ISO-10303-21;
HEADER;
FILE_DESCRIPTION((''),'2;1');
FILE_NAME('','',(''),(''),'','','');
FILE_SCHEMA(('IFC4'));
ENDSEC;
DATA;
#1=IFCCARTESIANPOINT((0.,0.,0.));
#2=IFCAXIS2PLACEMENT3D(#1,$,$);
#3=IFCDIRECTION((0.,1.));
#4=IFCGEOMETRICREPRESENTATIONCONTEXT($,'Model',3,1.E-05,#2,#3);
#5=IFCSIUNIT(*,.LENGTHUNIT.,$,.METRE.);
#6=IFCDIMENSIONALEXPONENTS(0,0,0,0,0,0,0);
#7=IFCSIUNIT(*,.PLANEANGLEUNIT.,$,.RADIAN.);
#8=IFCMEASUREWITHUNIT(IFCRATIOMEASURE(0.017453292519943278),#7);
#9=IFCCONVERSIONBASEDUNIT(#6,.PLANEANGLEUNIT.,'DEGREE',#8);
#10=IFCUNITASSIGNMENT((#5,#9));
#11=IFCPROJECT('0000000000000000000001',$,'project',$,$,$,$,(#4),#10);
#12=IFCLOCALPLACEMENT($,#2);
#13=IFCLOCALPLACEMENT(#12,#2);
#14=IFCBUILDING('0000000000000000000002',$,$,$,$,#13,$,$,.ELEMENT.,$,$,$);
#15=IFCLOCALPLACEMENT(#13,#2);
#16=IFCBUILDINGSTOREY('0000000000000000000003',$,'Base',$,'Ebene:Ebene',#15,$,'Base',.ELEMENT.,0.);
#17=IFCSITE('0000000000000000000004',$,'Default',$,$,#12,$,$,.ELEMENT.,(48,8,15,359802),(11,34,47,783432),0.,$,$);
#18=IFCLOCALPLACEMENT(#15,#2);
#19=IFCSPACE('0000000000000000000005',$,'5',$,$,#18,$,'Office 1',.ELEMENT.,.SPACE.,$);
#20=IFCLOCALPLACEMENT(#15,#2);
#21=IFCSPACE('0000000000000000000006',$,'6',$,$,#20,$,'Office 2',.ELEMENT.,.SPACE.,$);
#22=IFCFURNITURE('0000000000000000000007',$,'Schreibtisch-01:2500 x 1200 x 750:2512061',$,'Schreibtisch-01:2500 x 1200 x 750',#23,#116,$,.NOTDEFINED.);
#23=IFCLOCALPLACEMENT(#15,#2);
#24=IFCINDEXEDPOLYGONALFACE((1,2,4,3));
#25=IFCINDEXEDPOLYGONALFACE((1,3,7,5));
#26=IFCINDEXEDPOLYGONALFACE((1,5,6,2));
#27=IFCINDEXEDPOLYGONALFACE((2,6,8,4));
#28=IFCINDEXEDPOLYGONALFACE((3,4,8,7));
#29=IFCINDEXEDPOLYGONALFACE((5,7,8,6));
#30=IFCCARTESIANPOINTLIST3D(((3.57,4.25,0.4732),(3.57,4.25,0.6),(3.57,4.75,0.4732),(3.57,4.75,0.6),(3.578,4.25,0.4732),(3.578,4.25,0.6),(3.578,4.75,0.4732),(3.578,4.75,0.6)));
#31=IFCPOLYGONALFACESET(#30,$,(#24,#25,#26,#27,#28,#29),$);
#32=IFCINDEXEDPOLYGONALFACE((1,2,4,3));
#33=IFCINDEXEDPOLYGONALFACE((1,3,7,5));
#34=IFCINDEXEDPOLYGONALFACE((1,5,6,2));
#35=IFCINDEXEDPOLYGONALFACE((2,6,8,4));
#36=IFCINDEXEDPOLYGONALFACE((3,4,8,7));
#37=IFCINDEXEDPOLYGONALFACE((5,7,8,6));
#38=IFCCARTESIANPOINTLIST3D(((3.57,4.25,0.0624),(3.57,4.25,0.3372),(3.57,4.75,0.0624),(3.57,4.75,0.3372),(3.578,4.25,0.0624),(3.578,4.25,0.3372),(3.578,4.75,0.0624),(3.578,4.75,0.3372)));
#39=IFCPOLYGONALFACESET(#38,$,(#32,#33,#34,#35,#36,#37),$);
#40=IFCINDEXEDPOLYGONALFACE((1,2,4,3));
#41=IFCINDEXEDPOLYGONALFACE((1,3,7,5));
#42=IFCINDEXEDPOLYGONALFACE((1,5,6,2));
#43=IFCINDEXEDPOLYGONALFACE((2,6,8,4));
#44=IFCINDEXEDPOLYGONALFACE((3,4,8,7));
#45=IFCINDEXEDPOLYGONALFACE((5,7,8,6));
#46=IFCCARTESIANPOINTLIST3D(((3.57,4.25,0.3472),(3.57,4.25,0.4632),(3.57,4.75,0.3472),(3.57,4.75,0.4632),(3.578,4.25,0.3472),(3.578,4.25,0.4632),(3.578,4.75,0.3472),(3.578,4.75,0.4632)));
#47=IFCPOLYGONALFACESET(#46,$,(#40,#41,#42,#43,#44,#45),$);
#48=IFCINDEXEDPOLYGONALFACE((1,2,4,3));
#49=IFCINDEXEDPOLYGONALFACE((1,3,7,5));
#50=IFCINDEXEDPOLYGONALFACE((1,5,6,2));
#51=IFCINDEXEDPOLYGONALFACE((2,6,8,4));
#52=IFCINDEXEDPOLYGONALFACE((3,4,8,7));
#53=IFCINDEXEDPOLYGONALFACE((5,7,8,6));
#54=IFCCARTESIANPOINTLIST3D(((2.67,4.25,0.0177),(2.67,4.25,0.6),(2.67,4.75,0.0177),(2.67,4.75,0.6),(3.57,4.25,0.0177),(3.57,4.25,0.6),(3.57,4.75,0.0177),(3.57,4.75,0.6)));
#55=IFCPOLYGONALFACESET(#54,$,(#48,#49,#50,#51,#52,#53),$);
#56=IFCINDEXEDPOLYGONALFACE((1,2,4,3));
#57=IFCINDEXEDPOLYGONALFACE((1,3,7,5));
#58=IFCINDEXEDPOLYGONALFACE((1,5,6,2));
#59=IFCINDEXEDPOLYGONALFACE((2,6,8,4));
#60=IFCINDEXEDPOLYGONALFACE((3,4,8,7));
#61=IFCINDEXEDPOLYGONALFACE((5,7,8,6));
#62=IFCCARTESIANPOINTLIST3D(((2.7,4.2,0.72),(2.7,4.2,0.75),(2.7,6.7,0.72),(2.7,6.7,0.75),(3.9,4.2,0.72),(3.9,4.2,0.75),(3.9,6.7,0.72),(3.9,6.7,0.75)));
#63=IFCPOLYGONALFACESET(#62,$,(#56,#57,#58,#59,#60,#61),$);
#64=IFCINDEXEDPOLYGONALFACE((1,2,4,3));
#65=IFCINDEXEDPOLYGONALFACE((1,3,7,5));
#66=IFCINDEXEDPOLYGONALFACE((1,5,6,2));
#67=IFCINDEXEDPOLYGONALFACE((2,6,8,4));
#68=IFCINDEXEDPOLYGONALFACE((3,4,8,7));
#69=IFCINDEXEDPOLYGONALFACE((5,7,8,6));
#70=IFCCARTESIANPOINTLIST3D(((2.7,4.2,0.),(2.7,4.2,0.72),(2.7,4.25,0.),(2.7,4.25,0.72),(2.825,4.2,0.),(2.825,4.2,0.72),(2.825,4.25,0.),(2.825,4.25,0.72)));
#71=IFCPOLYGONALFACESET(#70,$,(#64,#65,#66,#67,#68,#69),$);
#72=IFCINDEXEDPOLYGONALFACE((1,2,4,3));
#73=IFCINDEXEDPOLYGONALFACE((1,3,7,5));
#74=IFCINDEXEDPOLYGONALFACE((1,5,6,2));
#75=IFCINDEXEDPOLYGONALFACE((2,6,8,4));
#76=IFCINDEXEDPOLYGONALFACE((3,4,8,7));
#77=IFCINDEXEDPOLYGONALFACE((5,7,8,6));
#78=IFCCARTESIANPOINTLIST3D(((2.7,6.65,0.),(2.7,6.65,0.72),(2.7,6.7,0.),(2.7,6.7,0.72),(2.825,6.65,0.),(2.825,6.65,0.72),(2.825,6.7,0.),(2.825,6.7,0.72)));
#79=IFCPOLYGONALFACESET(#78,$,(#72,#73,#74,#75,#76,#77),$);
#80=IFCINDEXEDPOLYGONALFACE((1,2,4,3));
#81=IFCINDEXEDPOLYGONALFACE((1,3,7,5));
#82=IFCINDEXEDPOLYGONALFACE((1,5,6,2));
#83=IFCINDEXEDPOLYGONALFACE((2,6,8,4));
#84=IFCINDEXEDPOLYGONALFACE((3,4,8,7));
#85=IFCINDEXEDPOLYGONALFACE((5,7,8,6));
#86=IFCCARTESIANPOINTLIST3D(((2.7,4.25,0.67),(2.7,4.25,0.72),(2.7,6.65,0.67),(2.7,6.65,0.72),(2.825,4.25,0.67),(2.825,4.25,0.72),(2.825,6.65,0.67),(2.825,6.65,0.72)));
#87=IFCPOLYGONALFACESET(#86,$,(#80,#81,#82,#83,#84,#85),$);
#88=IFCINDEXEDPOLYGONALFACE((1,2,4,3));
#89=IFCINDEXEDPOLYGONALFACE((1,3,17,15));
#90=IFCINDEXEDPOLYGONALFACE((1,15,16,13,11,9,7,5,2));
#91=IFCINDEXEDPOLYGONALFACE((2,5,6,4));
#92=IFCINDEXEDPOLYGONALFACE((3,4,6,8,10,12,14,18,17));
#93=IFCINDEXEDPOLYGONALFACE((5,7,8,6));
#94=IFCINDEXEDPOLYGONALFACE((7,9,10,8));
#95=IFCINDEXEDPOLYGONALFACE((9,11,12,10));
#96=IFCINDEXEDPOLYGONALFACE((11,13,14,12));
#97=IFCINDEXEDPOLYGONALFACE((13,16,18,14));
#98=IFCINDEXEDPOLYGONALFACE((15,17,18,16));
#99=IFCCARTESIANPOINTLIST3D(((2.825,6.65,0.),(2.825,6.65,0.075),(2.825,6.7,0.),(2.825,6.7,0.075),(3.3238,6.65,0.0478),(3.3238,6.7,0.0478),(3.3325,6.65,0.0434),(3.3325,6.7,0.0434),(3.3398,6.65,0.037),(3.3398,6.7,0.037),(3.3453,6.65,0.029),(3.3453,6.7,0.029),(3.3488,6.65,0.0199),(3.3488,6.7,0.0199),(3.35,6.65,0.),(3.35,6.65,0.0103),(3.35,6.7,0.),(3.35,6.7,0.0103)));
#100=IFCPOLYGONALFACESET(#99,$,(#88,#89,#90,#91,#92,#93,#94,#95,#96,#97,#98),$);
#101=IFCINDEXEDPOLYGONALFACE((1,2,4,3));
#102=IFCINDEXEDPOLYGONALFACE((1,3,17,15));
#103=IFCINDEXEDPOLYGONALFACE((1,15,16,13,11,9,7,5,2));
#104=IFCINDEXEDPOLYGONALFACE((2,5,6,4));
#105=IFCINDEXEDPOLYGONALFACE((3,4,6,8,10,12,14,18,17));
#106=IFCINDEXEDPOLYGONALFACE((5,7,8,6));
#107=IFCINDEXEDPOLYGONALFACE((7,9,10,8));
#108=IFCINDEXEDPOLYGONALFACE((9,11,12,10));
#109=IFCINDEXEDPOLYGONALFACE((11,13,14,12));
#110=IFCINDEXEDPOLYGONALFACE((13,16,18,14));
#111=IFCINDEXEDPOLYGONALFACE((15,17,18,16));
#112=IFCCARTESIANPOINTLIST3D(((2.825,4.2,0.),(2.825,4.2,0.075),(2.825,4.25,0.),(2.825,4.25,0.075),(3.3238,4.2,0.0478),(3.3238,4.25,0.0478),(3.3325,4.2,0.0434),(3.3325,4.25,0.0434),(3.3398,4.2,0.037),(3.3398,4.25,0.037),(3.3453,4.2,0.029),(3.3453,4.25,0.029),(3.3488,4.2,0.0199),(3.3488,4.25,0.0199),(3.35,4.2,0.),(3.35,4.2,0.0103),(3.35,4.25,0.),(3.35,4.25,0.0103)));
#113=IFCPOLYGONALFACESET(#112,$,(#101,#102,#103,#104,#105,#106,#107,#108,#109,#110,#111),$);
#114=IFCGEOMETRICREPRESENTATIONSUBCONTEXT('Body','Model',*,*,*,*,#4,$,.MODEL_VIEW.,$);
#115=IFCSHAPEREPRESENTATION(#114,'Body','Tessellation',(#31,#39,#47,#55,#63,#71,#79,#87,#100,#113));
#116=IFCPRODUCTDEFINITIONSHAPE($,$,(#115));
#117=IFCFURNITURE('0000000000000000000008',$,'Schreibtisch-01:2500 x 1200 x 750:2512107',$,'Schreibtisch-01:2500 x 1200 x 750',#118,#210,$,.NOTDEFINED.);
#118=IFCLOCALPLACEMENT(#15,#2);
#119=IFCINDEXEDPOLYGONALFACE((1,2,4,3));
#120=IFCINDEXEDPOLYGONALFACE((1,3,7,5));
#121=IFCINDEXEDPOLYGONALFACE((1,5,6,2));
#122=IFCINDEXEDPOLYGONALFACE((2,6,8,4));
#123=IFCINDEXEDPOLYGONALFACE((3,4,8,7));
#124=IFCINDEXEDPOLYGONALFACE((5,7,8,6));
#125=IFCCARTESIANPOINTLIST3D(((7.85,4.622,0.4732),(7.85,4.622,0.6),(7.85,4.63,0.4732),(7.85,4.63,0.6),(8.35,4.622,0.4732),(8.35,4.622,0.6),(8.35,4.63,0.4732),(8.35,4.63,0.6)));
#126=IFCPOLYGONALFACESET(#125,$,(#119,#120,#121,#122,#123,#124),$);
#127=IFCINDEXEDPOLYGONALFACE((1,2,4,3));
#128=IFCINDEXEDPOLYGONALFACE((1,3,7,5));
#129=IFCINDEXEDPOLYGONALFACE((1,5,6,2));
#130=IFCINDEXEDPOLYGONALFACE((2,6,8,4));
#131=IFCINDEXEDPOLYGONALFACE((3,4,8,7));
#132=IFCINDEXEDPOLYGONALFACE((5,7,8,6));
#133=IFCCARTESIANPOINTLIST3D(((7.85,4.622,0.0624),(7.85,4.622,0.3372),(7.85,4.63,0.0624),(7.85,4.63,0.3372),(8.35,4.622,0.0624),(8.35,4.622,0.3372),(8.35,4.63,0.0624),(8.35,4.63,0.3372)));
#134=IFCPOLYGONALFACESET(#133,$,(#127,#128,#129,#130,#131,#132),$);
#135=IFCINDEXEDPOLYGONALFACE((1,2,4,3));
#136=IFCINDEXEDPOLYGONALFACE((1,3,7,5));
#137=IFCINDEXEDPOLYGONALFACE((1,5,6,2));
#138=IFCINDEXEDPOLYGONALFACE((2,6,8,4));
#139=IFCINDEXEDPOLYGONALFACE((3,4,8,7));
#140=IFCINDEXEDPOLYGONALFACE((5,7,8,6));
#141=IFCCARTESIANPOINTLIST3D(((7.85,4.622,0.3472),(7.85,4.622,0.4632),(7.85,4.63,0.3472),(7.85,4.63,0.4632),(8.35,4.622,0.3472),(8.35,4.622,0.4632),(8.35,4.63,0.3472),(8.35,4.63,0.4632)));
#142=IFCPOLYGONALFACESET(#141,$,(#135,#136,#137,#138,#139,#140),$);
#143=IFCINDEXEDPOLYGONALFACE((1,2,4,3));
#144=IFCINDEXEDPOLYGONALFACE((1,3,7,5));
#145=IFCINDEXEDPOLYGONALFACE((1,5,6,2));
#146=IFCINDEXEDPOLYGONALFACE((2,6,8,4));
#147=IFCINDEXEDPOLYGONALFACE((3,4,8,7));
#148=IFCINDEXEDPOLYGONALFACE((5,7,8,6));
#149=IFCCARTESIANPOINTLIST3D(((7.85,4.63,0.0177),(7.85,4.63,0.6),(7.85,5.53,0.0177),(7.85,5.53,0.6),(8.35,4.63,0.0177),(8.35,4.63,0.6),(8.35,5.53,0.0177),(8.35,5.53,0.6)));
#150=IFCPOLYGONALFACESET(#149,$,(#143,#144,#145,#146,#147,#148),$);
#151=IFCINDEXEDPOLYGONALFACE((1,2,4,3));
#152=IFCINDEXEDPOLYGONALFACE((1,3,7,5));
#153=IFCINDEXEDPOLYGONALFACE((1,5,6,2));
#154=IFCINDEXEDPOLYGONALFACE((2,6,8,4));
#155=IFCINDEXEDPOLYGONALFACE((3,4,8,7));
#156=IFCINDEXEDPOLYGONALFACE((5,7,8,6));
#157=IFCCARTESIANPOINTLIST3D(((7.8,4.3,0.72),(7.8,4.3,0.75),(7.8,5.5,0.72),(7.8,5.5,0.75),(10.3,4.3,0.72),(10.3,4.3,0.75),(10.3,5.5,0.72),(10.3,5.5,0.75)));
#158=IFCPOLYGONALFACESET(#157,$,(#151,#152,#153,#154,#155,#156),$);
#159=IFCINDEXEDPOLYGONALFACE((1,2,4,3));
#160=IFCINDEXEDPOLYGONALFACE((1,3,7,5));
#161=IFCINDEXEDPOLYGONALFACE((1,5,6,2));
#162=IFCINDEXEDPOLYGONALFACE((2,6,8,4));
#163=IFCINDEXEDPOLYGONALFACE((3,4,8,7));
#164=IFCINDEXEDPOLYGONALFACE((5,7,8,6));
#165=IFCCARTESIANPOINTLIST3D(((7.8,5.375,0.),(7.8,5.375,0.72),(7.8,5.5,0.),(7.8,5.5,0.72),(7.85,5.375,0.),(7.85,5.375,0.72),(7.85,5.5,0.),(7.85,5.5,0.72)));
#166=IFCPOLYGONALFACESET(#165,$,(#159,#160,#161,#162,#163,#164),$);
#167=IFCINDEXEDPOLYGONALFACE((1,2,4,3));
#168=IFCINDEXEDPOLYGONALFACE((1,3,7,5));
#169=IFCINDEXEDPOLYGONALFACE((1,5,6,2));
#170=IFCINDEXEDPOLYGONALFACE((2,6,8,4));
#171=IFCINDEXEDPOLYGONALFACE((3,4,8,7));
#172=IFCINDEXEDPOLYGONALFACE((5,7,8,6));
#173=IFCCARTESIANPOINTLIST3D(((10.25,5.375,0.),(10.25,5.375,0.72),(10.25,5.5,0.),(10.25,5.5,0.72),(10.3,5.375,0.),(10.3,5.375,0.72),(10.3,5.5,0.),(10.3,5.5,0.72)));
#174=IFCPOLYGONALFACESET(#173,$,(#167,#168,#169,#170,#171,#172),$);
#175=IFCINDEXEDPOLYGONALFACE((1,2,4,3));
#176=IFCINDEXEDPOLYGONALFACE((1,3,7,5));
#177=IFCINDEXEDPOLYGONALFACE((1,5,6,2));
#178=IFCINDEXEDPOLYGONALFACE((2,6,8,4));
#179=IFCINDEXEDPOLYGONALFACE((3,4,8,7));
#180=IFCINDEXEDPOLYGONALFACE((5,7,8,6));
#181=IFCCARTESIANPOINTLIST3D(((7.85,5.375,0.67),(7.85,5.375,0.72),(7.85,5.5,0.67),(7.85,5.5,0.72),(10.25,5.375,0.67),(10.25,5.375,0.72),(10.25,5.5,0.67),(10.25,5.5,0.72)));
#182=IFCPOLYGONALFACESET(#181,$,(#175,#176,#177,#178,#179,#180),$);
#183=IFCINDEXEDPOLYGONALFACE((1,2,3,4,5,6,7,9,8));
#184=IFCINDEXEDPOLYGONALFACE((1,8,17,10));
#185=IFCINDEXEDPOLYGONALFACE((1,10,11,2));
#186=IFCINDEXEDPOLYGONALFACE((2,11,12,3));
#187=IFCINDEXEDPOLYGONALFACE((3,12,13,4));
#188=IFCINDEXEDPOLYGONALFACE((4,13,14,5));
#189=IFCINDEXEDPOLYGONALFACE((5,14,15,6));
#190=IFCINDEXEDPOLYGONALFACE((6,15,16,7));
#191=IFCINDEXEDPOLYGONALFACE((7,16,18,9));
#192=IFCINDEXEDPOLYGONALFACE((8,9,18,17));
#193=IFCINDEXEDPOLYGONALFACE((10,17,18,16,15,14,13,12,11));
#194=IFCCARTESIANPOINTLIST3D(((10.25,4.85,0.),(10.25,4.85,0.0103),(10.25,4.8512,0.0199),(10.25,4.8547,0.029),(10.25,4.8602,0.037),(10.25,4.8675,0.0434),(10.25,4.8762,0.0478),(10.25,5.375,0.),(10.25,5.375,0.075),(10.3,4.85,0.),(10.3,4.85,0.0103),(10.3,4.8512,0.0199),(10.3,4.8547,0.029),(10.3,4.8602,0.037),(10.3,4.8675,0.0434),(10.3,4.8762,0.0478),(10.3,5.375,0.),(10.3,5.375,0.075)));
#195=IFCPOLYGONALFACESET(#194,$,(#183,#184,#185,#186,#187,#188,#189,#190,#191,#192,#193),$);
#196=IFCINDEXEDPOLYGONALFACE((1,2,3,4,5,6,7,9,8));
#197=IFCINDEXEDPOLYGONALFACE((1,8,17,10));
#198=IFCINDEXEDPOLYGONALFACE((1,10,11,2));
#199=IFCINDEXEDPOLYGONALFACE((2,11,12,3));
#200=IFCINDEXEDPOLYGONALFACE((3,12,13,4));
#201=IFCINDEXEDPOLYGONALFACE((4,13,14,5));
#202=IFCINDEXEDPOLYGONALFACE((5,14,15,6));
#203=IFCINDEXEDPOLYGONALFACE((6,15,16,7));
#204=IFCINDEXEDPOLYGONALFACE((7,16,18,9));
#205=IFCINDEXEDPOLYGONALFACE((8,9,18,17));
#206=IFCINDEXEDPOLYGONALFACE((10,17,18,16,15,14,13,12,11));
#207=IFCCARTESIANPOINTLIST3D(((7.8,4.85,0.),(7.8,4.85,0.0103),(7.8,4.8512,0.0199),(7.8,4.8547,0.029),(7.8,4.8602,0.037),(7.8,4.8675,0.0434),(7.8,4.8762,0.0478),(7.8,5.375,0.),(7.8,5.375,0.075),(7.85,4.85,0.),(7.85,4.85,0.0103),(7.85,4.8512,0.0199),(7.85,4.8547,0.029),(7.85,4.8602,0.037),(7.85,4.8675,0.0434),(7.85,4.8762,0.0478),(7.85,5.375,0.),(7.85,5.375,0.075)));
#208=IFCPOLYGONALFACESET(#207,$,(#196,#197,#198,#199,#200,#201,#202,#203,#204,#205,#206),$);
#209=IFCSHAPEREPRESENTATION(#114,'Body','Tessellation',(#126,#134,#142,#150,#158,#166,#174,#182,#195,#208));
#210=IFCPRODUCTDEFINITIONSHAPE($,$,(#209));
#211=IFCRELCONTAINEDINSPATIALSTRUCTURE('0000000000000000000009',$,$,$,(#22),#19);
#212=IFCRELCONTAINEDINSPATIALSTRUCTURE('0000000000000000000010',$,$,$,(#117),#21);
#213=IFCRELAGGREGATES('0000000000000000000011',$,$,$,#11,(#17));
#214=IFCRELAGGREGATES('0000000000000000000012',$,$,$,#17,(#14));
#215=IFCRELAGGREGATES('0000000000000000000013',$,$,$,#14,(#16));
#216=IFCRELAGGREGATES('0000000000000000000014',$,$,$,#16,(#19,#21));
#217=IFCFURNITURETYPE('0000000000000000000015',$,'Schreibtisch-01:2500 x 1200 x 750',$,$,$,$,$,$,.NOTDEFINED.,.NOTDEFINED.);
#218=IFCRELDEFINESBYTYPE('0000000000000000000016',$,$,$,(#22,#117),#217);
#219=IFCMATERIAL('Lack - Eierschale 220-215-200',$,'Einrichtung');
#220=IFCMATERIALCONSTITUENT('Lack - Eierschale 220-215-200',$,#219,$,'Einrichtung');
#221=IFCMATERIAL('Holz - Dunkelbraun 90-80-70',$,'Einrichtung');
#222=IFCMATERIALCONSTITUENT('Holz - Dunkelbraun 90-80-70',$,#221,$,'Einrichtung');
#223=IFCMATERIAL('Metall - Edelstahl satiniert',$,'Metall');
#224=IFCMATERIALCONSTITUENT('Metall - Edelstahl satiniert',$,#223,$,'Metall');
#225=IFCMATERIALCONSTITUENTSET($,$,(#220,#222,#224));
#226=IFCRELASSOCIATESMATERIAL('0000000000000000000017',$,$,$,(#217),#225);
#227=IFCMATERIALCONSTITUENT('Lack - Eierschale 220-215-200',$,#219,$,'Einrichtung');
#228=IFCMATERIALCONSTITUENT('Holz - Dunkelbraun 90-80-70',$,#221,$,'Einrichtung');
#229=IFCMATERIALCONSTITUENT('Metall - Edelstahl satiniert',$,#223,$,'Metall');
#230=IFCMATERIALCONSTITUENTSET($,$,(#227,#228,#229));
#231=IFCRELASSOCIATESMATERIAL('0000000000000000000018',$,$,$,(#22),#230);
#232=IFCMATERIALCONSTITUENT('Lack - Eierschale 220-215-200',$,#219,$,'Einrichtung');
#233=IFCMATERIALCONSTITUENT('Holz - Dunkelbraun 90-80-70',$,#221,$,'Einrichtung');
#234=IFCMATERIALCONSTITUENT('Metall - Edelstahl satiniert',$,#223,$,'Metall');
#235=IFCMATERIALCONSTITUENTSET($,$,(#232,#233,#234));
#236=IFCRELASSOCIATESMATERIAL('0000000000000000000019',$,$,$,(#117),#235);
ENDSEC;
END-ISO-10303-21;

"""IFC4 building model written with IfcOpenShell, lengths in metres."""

from ifc_helpers import new_model, entity, si_unit, converted_unit, direction, frame, origin, place, context, subcontext, project, spatial, line, arc, indexed_curve, outline, extrude, source, transform, mapped, material, constituent, constituent_set, type_object, type_shapes, element, save


model = new_model("IFC4")

# Units and contexts
model_context = context("Model", 3, precision=1e-05, world=origin(), true_north=direction((0.0, 1.0)))
body_context = subcontext(model_context, "Body", "Model", "MODEL_VIEW")
ifc_project = project(units=[si_unit("LENGTHUNIT", "METRE"), converted_unit("PLANEANGLEUNIT", "DEGREE", entity("IfcRatioMeasure", 0.017453292519943278), si_unit("PLANEANGLEUNIT", "RADIAN"), dimensions=[0, 0, 0, 0, 0, 0, 0])], contexts=[model_context])

# Site, building, storey
site_placement = place(None, origin())
site = spatial("IfcSite", under=ifc_project, at=site_placement, Name="Default", CompositionType="ELEMENT", RefLatitude=(48, 8, 15, 359802), RefLongitude=(11, 34, 47, 783432), RefElevation=0.0)
building_placement = place(site_placement, origin())
building = spatial("IfcBuilding", under=site, at=building_placement, CompositionType="ELEMENT")
storey_placement = place(building_placement, origin())
storey = spatial("IfcBuildingStorey", under=building, at=storey_placement, Name="Base", ObjectType="Ebene:Ebene", LongName="Base", CompositionType="ELEMENT", Elevation=0.0)

# Shared definitions
ifc_material_1 = material(Name="Holz - Dunkelbraun 90-80-70", Category="Einrichtung")

# Shared definitions
space_1_placement = place(storey_placement, origin())
space_1 = spatial("IfcSpace", under=storey, at=space_1_placement, Name="5", LongName="Office 1", CompositionType="ELEMENT", PredefinedType="SPACE")

# Furniture
ifc_material_2 = material(Name="Lack - Eierschale 220-215-200", Category="Einrichtung")
ifc_material_3 = material(Name="Metall - Edelstahl satiniert", Category="Metall")
ifc_constituent_1 = constituent(ifc_material_2, Name="Lack - Eierschale 220-215-200", Category="Einrichtung")
ifc_constituent_2 = constituent(ifc_material_1, Name="Holz - Dunkelbraun 90-80-70", Category="Einrichtung")
ifc_constituent_3 = constituent(ifc_material_3, Name="Metall - Edelstahl satiniert", Category="Metall")
ifc_constituent_set_1 = constituent_set(constituents=[ifc_constituent_1, ifc_constituent_2, ifc_constituent_3])
furniture_type_1 = type_object("IfcFurnitureType", Name="Schreibtisch-01:2500 x 1200 x 750", AssemblyPlace="NOTDEFINED", PredefinedType="NOTDEFINED", material=ifc_constituent_set_1)
shared_shape_1 = source(origin(), body_context, "Body", "SweptSolid", [
    extrude(outline(indexed_curve([(-0.004, -0.25), (0.004, -0.25), (0.004, 0.25), (-0.004, 0.25), (-0.004, -0.25)], self_intersect=False)), frame((0.95, 0.574, 0.4732), z_axis=(0.0, 0.0, 1.0), x_axis=(0.0, 1.0, 0.0)), (0.0, 0.0, 1.0), 0.1268),
    extrude(outline(indexed_curve([(-0.004, -0.25), (0.004, -0.25), (0.004, 0.25), (-0.004, 0.25), (-0.004, -0.25)], self_intersect=False)), frame((0.95, 0.574, 0.0624), z_axis=(0.0, 0.0, 1.0), x_axis=(0.0, 1.0, 0.0)), (0.0, 0.0, 1.0), 0.2748),
    extrude(outline(indexed_curve([(-0.004, -0.25), (0.004, -0.25), (0.004, 0.25), (-0.004, 0.25), (-0.004, -0.25)], self_intersect=False)), frame((0.95, 0.574, 0.3472), z_axis=(0.0, 0.0, 1.0), x_axis=(0.0, 1.0, 0.0)), (0.0, 0.0, 1.0), 0.116),
    extrude(outline(indexed_curve([(-0.25, -0.45), (0.25, -0.45), (0.25, 0.45), (-0.25, 0.45), (-0.25, -0.45)], self_intersect=False)), frame((0.95, 0.12, 0.0177)), (0.0, 0.0, 1.0), 0.5823),
    extrude(outline(indexed_curve([(-1.25, -0.6), (1.25, -0.6), (1.25, 0.6), (-1.25, 0.6), (-1.25, -0.6)], self_intersect=False)), frame((0.0, 0.3, 0.72), z_axis=(0.0, 0.0, 1.0), x_axis=(-1.0, 0.0, 0.0)), (0.0, 0.0, 1.0), 0.03),
    extrude(outline(indexed_curve([(-0.025, -0.0625), (0.025, -0.0625), (0.025, 0.0625), (-0.025, 0.0625), (-0.025, -0.0625)], self_intersect=False)), frame((1.225, -0.2375, 0.0)), (0.0, 0.0, 1.0), 0.72),
    extrude(outline(indexed_curve([(-0.0625, -0.025), (0.0625, -0.025), (0.0625, 0.025), (-0.0625, 0.025), (-0.0625, -0.025)], self_intersect=False)), frame((-1.225, -0.2375, 0.0), z_axis=(0.0, 0.0, 1.0), x_axis=(0.0, 1.0, 0.0)), (0.0, 0.0, 1.0), 0.72),
    extrude(outline(indexed_curve([(-0.0625, -1.2), (0.0625, -1.2), (0.0625, 1.2), (-0.0625, 1.2), (-0.0625, -1.2)], self_intersect=False)), frame((0.0, -0.2375, 0.67), z_axis=(0.0, 0.0, 1.0), x_axis=(0.0, 1.0, 0.0)), (0.0, 0.0, 1.0), 0.05),
    extrude(outline(indexed_curve([(-0.0266, -0.2152), (-0.0163, -0.2152), (0.0065, -0.208), (0.0212, -0.189), (0.0484, 0.3098), (-0.0266, 0.3098)], segments=[line(1, 2), arc(2, 3, 4), line(4, 5, 6, 1)], self_intersect=False)), frame((-1.25, 0.1348, 0.0266), z_axis=(1.0, 0.0, 0.0), x_axis=(0.0, 0.0, 1.0)), (0.0, 0.0, 1.0), 0.05),
    extrude(outline(indexed_curve([(-0.0266, -0.2152), (-0.0163, -0.2152), (0.0065, -0.208), (0.0212, -0.189), (0.0484, 0.3098), (-0.0266, 0.3098)], segments=[line(1, 2), arc(2, 3, 4), line(4, 5, 6, 1)], self_intersect=False)), frame((1.2, 0.1348, 0.0266), z_axis=(1.0, 0.0, 0.0), x_axis=(0.0, 0.0, 1.0)), (0.0, 0.0, 1.0), 0.05),
])
type_shapes(furniture_type_1, [shared_shape_1])
ifc_constituent_4 = constituent(ifc_material_2, Name="Lack - Eierschale 220-215-200", Category="Einrichtung")
ifc_constituent_5 = constituent(ifc_material_1, Name="Holz - Dunkelbraun 90-80-70", Category="Einrichtung")
ifc_constituent_6 = constituent(ifc_material_3, Name="Metall - Edelstahl satiniert", Category="Metall")
ifc_constituent_set_2 = constituent_set(constituents=[ifc_constituent_4, ifc_constituent_5, ifc_constituent_6])
furniture_1_placement = place(space_1_placement, frame((3.0, 5.45, 0.0), z_axis=(0.0, 0.0, 1.0), x_axis=(0.0, -1.0, 0.0)))
element("IfcFurniture", 1, at=furniture_1_placement, inside=space_1, type_object=furniture_type_1, material=ifc_constituent_set_2, Name="Schreibtisch-01:2500 x 1200 x 750:2512061", ObjectType="Schreibtisch-01:2500 x 1200 x 750", PredefinedType="NOTDEFINED", context=body_context, shape_type="MappedRepresentation", body=[
    mapped(shared_shape_1, transform((0.0, 0.0, 0.0), scale=1.0)),
])

# Shared definitions
space_2_placement = place(storey_placement, origin())
space_2 = spatial("IfcSpace", under=storey, at=space_2_placement, Name="6", LongName="Office 2", CompositionType="ELEMENT", PredefinedType="SPACE")

# Furniture
ifc_constituent_7 = constituent(ifc_material_2, Name="Lack - Eierschale 220-215-200", Category="Einrichtung")
ifc_constituent_8 = constituent(ifc_material_1, Name="Holz - Dunkelbraun 90-80-70", Category="Einrichtung")
ifc_constituent_9 = constituent(ifc_material_3, Name="Metall - Edelstahl satiniert", Category="Metall")
ifc_constituent_set_3 = constituent_set(constituents=[ifc_constituent_7, ifc_constituent_8, ifc_constituent_9])
furniture_2_placement = place(space_2_placement, frame((9.05, 5.2, 0.0), z_axis=(0.0, 0.0, 1.0), x_axis=(-1.0, 0.0, 0.0)))
element("IfcFurniture", 2, at=furniture_2_placement, inside=space_2, type_object=furniture_type_1, material=ifc_constituent_set_3, Name="Schreibtisch-01:2500 x 1200 x 750:2512107", ObjectType="Schreibtisch-01:2500 x 1200 x 750", PredefinedType="NOTDEFINED", context=body_context, shape_type="MappedRepresentation", body=[
    mapped(shared_shape_1, transform((0.0, 0.0, 0.0), scale=1.0)),
])

save(model, "model.ifc")
